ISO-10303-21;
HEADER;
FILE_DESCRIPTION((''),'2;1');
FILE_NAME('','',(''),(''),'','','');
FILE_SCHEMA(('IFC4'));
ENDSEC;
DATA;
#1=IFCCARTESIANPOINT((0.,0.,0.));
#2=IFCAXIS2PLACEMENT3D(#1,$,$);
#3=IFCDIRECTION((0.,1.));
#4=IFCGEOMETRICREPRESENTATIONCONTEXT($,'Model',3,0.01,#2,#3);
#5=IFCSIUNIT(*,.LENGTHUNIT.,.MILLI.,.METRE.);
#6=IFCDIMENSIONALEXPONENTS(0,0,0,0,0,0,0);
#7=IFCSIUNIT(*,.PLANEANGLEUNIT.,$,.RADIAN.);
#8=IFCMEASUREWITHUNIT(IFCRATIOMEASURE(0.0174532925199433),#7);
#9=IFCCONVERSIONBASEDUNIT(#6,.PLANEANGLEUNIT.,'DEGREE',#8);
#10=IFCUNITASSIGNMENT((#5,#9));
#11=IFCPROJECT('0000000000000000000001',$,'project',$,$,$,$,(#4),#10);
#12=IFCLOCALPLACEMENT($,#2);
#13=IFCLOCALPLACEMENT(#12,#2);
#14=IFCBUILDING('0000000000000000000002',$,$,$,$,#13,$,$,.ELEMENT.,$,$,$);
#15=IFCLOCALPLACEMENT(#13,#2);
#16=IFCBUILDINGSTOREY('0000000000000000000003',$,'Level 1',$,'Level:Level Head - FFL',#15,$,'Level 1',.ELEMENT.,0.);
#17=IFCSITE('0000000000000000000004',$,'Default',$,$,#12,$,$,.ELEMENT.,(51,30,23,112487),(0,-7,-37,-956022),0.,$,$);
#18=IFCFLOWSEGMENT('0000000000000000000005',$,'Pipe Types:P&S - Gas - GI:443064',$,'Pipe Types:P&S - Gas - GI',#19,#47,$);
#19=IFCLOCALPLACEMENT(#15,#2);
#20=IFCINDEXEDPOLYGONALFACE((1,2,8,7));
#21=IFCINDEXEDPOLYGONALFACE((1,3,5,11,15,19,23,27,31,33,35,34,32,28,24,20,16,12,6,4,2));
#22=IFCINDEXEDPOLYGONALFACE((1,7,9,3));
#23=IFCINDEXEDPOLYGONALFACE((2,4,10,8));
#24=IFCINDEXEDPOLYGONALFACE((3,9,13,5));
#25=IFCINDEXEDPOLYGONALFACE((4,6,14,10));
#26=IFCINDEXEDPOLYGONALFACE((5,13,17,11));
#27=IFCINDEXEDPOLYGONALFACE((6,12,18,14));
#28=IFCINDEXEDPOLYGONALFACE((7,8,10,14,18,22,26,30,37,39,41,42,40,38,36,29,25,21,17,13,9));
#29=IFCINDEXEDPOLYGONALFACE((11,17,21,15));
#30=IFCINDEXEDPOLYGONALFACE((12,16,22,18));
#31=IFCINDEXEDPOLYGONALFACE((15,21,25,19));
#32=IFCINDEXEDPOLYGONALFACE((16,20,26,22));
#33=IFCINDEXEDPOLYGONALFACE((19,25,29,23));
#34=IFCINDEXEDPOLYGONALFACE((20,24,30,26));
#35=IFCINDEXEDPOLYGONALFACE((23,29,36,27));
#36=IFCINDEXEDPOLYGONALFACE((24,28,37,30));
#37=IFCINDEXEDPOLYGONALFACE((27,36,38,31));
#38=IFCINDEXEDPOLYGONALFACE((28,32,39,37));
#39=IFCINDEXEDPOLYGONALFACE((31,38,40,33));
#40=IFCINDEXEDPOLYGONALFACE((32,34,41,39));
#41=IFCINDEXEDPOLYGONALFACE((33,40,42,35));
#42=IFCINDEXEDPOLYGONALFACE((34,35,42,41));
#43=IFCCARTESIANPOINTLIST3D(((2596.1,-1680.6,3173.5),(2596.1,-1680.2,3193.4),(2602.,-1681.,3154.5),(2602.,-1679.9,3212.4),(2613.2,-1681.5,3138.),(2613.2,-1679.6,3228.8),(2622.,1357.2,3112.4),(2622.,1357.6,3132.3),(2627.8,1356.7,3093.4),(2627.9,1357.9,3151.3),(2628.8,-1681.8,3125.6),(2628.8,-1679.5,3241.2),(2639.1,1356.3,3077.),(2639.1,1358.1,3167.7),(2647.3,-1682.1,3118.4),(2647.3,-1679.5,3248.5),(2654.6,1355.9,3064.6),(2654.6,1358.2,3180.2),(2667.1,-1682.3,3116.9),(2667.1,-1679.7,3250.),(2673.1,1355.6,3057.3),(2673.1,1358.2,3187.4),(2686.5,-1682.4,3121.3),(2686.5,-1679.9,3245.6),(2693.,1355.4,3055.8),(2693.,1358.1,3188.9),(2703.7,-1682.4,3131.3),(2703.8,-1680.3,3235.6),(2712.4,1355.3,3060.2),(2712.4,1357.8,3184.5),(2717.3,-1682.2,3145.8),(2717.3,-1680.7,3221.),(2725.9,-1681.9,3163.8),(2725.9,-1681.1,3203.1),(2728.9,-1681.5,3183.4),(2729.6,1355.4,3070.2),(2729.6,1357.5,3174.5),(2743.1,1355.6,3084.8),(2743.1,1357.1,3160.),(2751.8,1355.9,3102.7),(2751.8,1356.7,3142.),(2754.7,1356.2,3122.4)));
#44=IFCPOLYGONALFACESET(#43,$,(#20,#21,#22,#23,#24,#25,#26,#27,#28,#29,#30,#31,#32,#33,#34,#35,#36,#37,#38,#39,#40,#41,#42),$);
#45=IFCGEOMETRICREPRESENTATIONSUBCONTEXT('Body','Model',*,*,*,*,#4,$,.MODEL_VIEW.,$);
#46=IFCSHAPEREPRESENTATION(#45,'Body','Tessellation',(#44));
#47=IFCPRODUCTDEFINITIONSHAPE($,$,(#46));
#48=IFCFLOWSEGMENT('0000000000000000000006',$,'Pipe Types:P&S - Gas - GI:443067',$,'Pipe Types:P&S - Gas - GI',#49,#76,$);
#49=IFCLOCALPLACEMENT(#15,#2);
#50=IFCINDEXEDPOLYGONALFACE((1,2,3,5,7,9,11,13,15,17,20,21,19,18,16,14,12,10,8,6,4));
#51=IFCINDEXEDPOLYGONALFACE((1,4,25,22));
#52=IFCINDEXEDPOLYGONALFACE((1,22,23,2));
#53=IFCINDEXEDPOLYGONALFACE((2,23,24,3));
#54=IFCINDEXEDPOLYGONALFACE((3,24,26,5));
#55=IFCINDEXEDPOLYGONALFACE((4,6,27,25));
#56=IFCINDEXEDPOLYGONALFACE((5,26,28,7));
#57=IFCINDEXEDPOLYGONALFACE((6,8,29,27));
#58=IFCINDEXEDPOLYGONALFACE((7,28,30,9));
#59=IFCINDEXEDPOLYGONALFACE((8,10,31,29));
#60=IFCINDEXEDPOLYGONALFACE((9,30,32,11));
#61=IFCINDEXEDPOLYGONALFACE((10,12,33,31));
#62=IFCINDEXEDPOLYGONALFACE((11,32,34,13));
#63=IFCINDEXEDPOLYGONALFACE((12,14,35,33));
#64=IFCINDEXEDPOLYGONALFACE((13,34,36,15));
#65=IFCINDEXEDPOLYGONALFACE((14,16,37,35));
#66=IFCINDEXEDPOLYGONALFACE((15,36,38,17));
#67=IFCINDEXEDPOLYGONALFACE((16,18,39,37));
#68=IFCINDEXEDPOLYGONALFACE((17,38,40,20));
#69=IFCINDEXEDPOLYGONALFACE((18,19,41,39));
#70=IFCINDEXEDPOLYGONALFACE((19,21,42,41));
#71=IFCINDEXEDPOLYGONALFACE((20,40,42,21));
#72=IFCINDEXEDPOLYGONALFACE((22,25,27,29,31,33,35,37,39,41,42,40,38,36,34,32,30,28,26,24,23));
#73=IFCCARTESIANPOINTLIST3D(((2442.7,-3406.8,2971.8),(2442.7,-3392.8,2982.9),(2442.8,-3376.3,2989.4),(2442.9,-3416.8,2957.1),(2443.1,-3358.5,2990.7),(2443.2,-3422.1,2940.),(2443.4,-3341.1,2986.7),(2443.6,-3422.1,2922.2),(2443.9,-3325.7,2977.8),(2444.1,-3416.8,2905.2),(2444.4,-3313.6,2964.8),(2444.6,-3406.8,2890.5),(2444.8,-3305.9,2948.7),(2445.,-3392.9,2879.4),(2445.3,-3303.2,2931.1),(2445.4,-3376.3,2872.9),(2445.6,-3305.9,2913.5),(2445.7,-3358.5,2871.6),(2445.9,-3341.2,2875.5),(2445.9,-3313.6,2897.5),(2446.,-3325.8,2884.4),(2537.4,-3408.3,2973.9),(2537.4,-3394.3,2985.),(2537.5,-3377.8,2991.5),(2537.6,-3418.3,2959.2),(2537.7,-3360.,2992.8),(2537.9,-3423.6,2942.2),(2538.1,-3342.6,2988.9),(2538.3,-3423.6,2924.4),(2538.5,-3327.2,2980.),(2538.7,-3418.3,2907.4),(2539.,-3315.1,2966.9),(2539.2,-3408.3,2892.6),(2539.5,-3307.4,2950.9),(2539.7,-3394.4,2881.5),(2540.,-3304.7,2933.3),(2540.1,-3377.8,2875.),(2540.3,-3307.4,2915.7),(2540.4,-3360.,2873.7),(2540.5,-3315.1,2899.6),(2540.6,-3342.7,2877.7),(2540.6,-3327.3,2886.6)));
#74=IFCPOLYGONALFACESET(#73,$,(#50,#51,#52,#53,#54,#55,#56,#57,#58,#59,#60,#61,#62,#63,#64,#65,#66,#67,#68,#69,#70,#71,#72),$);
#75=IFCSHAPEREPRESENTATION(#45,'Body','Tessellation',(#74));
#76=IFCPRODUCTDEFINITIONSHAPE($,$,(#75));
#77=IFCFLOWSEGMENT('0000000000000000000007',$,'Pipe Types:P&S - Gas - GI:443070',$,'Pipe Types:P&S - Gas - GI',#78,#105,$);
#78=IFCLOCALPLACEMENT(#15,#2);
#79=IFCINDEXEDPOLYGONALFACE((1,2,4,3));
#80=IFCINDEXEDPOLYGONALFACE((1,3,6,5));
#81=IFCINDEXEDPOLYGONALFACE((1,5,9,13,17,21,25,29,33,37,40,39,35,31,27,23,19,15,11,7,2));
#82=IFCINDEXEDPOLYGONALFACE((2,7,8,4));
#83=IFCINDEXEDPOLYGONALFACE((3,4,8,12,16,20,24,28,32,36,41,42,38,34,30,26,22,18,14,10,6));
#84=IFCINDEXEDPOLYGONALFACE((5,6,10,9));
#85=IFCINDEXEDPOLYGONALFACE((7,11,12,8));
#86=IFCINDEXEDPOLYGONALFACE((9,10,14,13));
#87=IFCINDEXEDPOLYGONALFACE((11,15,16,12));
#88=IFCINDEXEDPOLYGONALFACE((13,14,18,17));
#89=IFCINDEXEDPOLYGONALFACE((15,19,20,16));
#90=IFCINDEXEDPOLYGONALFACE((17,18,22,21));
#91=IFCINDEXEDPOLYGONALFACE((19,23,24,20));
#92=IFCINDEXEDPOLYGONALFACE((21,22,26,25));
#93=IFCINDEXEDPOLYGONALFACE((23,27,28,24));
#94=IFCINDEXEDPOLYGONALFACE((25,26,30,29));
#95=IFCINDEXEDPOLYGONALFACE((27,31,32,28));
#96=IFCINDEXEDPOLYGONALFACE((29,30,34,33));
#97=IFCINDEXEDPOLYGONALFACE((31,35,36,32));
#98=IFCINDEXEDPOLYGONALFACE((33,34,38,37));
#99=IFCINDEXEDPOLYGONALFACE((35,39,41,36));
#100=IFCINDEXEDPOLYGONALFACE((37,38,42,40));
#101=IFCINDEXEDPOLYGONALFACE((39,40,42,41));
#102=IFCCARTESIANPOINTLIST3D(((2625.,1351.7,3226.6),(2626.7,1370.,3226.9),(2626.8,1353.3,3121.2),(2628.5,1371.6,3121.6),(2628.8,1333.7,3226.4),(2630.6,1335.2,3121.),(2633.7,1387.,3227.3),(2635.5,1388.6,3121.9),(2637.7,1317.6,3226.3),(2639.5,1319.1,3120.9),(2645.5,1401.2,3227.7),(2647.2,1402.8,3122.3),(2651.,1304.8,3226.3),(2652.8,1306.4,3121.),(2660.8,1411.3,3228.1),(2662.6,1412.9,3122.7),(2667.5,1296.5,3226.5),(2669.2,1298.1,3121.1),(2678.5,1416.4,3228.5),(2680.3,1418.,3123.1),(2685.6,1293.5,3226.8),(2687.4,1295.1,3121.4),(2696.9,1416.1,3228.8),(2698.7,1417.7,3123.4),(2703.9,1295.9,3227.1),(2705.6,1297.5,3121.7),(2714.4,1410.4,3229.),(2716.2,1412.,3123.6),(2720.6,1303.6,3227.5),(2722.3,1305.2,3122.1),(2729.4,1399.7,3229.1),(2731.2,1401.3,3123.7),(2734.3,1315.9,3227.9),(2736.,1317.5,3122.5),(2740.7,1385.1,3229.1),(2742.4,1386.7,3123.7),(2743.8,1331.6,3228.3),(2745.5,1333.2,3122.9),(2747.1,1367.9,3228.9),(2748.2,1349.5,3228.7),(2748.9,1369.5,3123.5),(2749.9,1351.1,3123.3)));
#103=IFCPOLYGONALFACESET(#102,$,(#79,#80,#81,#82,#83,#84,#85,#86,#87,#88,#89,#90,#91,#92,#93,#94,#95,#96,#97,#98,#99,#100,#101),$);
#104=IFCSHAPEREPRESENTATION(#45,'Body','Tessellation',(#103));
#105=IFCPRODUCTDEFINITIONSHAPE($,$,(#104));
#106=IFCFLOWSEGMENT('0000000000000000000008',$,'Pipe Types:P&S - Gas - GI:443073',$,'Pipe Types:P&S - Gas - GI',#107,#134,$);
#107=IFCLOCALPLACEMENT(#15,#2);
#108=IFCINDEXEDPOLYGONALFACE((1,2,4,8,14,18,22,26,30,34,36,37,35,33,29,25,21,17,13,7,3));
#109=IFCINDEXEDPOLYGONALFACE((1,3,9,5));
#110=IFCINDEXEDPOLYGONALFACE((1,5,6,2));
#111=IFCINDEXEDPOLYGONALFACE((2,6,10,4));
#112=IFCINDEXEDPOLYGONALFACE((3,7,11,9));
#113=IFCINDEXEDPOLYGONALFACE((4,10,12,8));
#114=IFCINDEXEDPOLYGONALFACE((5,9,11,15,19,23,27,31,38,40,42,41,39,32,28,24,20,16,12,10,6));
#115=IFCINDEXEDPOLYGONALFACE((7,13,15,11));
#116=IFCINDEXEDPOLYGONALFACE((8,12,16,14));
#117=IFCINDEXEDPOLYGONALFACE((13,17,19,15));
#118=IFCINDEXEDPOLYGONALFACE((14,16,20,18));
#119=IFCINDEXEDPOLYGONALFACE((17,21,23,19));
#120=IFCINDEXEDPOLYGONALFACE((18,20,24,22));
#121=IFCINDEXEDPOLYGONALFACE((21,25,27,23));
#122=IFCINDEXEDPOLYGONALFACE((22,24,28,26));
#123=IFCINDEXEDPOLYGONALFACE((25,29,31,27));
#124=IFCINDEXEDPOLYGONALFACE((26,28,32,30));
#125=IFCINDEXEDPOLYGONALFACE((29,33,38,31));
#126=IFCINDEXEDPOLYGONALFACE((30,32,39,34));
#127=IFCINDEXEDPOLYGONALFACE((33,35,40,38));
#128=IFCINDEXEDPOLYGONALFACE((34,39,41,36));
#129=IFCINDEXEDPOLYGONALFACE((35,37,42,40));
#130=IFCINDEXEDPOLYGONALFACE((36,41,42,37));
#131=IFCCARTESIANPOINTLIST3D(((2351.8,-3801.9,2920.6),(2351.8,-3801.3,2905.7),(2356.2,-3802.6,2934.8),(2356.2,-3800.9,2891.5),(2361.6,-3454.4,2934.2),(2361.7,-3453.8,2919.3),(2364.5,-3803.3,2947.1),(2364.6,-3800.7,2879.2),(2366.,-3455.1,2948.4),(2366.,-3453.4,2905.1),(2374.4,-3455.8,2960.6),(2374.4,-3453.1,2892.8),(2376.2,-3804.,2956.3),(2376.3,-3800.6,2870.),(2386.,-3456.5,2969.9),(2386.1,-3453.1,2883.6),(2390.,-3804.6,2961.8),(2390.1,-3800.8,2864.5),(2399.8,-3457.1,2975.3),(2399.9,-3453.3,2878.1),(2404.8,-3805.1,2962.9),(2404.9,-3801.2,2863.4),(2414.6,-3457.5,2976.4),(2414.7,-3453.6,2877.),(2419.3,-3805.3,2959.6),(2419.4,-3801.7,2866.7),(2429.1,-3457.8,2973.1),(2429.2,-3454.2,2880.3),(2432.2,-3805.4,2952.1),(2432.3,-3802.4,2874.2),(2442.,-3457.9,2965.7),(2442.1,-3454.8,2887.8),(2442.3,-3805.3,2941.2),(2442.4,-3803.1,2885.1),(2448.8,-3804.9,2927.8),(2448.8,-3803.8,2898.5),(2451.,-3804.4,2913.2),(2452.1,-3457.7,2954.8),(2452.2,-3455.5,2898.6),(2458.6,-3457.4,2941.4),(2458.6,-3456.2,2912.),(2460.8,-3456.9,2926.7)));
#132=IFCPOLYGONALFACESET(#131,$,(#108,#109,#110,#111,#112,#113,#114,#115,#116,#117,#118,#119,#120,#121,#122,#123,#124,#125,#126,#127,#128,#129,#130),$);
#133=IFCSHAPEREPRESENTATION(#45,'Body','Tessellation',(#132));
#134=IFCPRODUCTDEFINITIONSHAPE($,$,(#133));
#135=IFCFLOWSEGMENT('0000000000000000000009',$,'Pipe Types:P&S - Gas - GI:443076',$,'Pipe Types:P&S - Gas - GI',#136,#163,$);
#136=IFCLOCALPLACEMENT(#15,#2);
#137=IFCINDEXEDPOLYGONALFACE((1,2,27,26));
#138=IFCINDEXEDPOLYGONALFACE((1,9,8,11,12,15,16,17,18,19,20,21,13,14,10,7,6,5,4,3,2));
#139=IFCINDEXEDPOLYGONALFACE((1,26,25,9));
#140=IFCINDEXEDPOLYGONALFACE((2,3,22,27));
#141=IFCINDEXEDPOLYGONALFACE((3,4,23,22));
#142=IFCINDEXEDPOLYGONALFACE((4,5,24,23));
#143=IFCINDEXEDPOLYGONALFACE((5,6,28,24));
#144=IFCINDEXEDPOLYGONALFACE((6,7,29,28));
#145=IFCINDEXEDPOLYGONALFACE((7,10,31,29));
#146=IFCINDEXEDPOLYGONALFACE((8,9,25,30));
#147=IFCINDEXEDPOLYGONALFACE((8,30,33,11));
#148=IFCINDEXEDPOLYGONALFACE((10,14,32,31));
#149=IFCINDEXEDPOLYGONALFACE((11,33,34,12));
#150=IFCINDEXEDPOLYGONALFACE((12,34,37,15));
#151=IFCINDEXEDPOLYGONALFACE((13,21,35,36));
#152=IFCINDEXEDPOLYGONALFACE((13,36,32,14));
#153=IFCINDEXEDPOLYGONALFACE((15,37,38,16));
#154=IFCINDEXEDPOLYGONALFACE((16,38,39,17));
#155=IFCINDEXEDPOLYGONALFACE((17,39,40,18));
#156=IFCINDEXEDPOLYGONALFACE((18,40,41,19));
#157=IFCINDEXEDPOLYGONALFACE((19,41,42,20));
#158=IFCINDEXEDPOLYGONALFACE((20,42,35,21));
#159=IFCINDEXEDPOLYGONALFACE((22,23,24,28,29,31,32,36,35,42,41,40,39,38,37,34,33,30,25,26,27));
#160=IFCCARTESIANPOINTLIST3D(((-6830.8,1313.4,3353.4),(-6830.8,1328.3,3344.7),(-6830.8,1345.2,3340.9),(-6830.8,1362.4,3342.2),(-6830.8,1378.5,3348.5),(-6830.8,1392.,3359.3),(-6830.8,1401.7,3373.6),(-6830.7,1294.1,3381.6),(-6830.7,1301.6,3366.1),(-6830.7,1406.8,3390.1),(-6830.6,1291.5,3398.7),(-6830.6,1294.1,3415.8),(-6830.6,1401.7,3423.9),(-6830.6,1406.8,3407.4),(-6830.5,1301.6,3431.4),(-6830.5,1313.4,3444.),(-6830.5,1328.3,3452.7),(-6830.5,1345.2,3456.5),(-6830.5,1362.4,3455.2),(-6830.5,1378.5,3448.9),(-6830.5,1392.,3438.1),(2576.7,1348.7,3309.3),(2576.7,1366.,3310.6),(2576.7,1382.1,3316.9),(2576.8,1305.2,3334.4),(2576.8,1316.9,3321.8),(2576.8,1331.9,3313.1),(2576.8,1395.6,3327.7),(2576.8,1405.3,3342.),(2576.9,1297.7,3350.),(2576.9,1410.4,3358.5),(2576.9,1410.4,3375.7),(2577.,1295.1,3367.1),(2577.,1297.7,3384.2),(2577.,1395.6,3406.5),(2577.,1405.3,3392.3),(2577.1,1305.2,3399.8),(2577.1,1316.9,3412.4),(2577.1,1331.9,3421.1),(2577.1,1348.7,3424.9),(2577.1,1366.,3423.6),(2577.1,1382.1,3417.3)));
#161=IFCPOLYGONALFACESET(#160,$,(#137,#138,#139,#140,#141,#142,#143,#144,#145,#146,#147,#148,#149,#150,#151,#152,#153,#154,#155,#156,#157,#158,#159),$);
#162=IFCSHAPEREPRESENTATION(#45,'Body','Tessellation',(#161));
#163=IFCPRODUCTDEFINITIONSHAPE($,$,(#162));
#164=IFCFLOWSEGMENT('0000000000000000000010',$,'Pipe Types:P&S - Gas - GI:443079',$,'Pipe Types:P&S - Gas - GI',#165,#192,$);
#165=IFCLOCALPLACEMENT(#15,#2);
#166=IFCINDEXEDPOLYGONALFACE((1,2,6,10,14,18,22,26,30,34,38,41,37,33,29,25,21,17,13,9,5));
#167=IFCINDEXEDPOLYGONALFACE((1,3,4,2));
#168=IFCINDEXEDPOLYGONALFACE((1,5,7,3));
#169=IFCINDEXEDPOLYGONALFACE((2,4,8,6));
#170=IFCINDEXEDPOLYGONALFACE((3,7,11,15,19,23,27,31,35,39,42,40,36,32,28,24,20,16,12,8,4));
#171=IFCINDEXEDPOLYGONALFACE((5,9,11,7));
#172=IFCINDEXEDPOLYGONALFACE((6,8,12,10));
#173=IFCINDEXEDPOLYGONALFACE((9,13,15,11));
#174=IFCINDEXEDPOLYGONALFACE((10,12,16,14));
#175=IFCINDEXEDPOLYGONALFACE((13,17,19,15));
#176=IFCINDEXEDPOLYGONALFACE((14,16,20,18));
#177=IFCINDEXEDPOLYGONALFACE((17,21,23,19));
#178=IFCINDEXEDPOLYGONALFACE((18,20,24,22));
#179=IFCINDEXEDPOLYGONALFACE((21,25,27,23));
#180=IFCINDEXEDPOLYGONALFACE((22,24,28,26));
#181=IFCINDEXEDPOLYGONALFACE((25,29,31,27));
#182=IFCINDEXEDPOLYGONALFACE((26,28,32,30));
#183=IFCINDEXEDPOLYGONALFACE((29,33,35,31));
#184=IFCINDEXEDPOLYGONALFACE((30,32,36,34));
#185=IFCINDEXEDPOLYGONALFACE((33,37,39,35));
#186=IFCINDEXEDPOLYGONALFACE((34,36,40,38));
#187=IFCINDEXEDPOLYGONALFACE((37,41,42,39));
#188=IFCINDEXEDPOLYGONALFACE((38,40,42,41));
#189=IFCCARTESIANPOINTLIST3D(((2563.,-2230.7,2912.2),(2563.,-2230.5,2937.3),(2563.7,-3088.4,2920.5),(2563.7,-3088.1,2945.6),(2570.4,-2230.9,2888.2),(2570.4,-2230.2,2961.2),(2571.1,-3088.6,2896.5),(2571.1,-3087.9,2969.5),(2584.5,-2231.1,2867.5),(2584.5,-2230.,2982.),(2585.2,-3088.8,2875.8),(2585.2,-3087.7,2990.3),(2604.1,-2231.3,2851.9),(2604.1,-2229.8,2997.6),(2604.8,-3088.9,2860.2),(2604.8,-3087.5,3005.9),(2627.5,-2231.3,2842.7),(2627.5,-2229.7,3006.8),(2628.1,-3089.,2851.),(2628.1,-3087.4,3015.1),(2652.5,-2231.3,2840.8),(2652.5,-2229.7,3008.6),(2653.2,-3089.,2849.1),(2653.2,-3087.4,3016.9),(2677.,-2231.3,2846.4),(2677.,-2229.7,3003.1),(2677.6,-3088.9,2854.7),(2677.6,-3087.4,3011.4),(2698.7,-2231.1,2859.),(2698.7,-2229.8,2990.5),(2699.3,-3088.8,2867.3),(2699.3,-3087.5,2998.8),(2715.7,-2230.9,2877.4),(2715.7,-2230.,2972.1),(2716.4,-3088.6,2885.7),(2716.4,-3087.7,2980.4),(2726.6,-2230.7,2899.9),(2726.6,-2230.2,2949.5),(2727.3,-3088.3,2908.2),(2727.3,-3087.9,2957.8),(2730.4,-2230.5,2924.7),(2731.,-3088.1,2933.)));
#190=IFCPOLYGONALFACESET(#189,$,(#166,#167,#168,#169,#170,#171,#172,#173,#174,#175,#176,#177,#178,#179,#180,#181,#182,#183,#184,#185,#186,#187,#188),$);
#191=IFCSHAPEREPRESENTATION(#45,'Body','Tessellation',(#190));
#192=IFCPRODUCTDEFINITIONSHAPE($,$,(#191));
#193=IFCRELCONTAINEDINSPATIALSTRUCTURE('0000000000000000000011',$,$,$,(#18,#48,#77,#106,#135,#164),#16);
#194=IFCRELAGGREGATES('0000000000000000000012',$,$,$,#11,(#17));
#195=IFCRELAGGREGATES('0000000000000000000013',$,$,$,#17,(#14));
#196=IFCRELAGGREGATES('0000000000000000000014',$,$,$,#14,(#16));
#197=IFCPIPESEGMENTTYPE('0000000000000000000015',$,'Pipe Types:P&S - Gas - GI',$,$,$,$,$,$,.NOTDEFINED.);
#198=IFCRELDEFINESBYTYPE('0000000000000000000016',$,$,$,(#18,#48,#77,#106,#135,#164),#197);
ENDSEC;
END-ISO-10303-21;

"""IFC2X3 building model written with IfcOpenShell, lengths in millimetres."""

from ifc_helpers import new_model, entity, si_unit, converted_unit, direction, frame, frame_2d, origin, origin_2d_with_axis, place, context, subcontext, project, spatial, circle, extrude, type_object, element, save


model = new_model("IFC2X3")

# Units and contexts
model_context = context("Model", 3, precision=0.01, world=origin(), true_north=direction((0.0, 1.0)))
body_context = subcontext(model_context, "Body", "Model", "MODEL_VIEW")
ifc_project = project(units=[si_unit("LENGTHUNIT", "METRE", prefix="MILLI"), converted_unit("PLANEANGLEUNIT", "DEGREE", entity("IfcRatioMeasure", 0.0174532925199433), si_unit("PLANEANGLEUNIT", "RADIAN"), dimensions=[0, 0, 0, 0, 0, 0, 0])], contexts=[model_context])

# Site, building, storey
site_placement = place(None, origin())
site = spatial("IfcSite", under=ifc_project, at=site_placement, Name="Default", CompositionType="ELEMENT", RefLatitude=(51, 30, 23, 112487), RefLongitude=(0, -7, -37, -956022), RefElevation=0.0)
building_placement = place(site_placement, origin())
building = spatial("IfcBuilding", under=site, at=building_placement, CompositionType="ELEMENT")
storey_placement = place(building_placement, origin())
storey = spatial("IfcBuildingStorey", under=building, at=storey_placement, Name="Level 1", ObjectType="Level:Level Head - FFL", LongName="Level 1", CompositionType="ELEMENT", Elevation=0.0)

# Flow segments
pipe_segment_type = type_object("IfcPipeSegmentType", Name="Pipe Types:P&S - Gas - GI", PredefinedType="NOTDEFINED")
flow_segment_1_placement = place(storey_placement, origin())
element("IfcFlowSegment", 1, at=flow_segment_1_placement, inside=storey, type_object=pipe_segment_type, Name="Pipe Types:P&S - Gas - GI:443064", ObjectType="Pipe Types:P&S - Gas - GI", context=body_context, shape_type="SweptSolid", body=[
    extrude(circle(Radius=66.7, at=frame_2d((0.0, 0.0), x_axis=(1.0, 0.0))), frame((2662.1, -1681.0, 3183.4), z_axis=(0.008509, 0.999762, -0.0201), x_axis=(0.999964, -0.00851, 0.0)), (0.0, 0.0, 1.0), 3038.5),
])
flow_segment_2_placement = place(storey_placement, origin())
element("IfcFlowSegment", 2, at=flow_segment_2_placement, inside=storey, type_object=pipe_segment_type, Name="Pipe Types:P&S - Gas - GI:443067", ObjectType="Pipe Types:P&S - Gas - GI", context=body_context, shape_type="SweptSolid", body=[
    extrude(circle(Radius=59.7, at=frame_2d((0.0, 0.0), x_axis=(1.0, 0.0))), frame((2539.0, -3364.5, 2933.3), z_axis=(-0.99962, 0.01587, -0.022546), x_axis=(0.015874, 0.999874, 0.0)), (0.0, 0.0, 1.0), 94.7),
])
flow_segment_3_placement = place(storey_placement, origin())
element("IfcFlowSegment", 3, at=flow_segment_3_placement, inside=storey, type_object=pipe_segment_type, Name="Pipe Types:P&S - Gas - GI:443070", ObjectType="Pipe Types:P&S - Gas - GI", context=body_context, shape_type="SweptSolid", body=[
    extrude(circle(Radius=61.8, at=origin_2d_with_axis()), frame((2686.7, 1355.2, 3227.7), z_axis=(0.0168, 0.015054, -0.999746), x_axis=(-0.667358, 0.744737, 0.0)), (0.0, 0.0, 1.0), 105.4),
])
flow_segment_4_placement = place(storey_placement, origin())
element("IfcFlowSegment", 4, at=flow_segment_4_placement, inside=storey, type_object=pipe_segment_type, Name="Pipe Types:P&S - Gas - GI:443073", ObjectType="Pipe Types:P&S - Gas - GI", context=body_context, shape_type="SweptSolid", body=[
    extrude(circle(Radius=49.9, at=frame_2d((0.0, 0.0), x_axis=(1.0, 0.0))), frame((2401.1, -3803.0, 2913.2), z_axis=(0.028196, 0.99884, 0.039027), x_axis=(0.999602, -0.028218, 0.0)), (0.0, 0.0, 1.0), 347.9),
])
flow_segment_5_placement = place(storey_placement, origin())
element("IfcFlowSegment", 5, at=flow_segment_5_placement, inside=storey, type_object=pipe_segment_type, Name="Pipe Types:P&S - Gas - GI:443076", ObjectType="Pipe Types:P&S - Gas - GI", context=body_context, shape_type="SweptSolid", body=[
    extrude(circle(Radius=58.0, at=origin_2d_with_axis()), frame((-6830.6, 1349.5, 3398.7), z_axis=(0.999994, 0.000379, -0.00336), x_axis=(0.000379, -1.0, 0.0)), (0.0, 0.0, 1.0), 9407.6),
])
flow_segment_6_placement = place(storey_placement, origin())
element("IfcFlowSegment", 6, at=flow_segment_6_placement, inside=storey, type_object=pipe_segment_type, Name="Pipe Types:P&S - Gas - GI:443079", ObjectType="Pipe Types:P&S - Gas - GI", context=body_context, shape_type="SweptSolid", body=[
    extrude(circle(Radius=84.1, at=origin_2d_with_axis()), frame((2646.2, -2230.5, 2924.7), z_axis=(0.000761, -0.999953, 0.009678), x_axis=(1.0, 0.000761, 0.0)), (0.0, 0.0, 1.0), 857.7),
])

save(model, "model.ifc")
